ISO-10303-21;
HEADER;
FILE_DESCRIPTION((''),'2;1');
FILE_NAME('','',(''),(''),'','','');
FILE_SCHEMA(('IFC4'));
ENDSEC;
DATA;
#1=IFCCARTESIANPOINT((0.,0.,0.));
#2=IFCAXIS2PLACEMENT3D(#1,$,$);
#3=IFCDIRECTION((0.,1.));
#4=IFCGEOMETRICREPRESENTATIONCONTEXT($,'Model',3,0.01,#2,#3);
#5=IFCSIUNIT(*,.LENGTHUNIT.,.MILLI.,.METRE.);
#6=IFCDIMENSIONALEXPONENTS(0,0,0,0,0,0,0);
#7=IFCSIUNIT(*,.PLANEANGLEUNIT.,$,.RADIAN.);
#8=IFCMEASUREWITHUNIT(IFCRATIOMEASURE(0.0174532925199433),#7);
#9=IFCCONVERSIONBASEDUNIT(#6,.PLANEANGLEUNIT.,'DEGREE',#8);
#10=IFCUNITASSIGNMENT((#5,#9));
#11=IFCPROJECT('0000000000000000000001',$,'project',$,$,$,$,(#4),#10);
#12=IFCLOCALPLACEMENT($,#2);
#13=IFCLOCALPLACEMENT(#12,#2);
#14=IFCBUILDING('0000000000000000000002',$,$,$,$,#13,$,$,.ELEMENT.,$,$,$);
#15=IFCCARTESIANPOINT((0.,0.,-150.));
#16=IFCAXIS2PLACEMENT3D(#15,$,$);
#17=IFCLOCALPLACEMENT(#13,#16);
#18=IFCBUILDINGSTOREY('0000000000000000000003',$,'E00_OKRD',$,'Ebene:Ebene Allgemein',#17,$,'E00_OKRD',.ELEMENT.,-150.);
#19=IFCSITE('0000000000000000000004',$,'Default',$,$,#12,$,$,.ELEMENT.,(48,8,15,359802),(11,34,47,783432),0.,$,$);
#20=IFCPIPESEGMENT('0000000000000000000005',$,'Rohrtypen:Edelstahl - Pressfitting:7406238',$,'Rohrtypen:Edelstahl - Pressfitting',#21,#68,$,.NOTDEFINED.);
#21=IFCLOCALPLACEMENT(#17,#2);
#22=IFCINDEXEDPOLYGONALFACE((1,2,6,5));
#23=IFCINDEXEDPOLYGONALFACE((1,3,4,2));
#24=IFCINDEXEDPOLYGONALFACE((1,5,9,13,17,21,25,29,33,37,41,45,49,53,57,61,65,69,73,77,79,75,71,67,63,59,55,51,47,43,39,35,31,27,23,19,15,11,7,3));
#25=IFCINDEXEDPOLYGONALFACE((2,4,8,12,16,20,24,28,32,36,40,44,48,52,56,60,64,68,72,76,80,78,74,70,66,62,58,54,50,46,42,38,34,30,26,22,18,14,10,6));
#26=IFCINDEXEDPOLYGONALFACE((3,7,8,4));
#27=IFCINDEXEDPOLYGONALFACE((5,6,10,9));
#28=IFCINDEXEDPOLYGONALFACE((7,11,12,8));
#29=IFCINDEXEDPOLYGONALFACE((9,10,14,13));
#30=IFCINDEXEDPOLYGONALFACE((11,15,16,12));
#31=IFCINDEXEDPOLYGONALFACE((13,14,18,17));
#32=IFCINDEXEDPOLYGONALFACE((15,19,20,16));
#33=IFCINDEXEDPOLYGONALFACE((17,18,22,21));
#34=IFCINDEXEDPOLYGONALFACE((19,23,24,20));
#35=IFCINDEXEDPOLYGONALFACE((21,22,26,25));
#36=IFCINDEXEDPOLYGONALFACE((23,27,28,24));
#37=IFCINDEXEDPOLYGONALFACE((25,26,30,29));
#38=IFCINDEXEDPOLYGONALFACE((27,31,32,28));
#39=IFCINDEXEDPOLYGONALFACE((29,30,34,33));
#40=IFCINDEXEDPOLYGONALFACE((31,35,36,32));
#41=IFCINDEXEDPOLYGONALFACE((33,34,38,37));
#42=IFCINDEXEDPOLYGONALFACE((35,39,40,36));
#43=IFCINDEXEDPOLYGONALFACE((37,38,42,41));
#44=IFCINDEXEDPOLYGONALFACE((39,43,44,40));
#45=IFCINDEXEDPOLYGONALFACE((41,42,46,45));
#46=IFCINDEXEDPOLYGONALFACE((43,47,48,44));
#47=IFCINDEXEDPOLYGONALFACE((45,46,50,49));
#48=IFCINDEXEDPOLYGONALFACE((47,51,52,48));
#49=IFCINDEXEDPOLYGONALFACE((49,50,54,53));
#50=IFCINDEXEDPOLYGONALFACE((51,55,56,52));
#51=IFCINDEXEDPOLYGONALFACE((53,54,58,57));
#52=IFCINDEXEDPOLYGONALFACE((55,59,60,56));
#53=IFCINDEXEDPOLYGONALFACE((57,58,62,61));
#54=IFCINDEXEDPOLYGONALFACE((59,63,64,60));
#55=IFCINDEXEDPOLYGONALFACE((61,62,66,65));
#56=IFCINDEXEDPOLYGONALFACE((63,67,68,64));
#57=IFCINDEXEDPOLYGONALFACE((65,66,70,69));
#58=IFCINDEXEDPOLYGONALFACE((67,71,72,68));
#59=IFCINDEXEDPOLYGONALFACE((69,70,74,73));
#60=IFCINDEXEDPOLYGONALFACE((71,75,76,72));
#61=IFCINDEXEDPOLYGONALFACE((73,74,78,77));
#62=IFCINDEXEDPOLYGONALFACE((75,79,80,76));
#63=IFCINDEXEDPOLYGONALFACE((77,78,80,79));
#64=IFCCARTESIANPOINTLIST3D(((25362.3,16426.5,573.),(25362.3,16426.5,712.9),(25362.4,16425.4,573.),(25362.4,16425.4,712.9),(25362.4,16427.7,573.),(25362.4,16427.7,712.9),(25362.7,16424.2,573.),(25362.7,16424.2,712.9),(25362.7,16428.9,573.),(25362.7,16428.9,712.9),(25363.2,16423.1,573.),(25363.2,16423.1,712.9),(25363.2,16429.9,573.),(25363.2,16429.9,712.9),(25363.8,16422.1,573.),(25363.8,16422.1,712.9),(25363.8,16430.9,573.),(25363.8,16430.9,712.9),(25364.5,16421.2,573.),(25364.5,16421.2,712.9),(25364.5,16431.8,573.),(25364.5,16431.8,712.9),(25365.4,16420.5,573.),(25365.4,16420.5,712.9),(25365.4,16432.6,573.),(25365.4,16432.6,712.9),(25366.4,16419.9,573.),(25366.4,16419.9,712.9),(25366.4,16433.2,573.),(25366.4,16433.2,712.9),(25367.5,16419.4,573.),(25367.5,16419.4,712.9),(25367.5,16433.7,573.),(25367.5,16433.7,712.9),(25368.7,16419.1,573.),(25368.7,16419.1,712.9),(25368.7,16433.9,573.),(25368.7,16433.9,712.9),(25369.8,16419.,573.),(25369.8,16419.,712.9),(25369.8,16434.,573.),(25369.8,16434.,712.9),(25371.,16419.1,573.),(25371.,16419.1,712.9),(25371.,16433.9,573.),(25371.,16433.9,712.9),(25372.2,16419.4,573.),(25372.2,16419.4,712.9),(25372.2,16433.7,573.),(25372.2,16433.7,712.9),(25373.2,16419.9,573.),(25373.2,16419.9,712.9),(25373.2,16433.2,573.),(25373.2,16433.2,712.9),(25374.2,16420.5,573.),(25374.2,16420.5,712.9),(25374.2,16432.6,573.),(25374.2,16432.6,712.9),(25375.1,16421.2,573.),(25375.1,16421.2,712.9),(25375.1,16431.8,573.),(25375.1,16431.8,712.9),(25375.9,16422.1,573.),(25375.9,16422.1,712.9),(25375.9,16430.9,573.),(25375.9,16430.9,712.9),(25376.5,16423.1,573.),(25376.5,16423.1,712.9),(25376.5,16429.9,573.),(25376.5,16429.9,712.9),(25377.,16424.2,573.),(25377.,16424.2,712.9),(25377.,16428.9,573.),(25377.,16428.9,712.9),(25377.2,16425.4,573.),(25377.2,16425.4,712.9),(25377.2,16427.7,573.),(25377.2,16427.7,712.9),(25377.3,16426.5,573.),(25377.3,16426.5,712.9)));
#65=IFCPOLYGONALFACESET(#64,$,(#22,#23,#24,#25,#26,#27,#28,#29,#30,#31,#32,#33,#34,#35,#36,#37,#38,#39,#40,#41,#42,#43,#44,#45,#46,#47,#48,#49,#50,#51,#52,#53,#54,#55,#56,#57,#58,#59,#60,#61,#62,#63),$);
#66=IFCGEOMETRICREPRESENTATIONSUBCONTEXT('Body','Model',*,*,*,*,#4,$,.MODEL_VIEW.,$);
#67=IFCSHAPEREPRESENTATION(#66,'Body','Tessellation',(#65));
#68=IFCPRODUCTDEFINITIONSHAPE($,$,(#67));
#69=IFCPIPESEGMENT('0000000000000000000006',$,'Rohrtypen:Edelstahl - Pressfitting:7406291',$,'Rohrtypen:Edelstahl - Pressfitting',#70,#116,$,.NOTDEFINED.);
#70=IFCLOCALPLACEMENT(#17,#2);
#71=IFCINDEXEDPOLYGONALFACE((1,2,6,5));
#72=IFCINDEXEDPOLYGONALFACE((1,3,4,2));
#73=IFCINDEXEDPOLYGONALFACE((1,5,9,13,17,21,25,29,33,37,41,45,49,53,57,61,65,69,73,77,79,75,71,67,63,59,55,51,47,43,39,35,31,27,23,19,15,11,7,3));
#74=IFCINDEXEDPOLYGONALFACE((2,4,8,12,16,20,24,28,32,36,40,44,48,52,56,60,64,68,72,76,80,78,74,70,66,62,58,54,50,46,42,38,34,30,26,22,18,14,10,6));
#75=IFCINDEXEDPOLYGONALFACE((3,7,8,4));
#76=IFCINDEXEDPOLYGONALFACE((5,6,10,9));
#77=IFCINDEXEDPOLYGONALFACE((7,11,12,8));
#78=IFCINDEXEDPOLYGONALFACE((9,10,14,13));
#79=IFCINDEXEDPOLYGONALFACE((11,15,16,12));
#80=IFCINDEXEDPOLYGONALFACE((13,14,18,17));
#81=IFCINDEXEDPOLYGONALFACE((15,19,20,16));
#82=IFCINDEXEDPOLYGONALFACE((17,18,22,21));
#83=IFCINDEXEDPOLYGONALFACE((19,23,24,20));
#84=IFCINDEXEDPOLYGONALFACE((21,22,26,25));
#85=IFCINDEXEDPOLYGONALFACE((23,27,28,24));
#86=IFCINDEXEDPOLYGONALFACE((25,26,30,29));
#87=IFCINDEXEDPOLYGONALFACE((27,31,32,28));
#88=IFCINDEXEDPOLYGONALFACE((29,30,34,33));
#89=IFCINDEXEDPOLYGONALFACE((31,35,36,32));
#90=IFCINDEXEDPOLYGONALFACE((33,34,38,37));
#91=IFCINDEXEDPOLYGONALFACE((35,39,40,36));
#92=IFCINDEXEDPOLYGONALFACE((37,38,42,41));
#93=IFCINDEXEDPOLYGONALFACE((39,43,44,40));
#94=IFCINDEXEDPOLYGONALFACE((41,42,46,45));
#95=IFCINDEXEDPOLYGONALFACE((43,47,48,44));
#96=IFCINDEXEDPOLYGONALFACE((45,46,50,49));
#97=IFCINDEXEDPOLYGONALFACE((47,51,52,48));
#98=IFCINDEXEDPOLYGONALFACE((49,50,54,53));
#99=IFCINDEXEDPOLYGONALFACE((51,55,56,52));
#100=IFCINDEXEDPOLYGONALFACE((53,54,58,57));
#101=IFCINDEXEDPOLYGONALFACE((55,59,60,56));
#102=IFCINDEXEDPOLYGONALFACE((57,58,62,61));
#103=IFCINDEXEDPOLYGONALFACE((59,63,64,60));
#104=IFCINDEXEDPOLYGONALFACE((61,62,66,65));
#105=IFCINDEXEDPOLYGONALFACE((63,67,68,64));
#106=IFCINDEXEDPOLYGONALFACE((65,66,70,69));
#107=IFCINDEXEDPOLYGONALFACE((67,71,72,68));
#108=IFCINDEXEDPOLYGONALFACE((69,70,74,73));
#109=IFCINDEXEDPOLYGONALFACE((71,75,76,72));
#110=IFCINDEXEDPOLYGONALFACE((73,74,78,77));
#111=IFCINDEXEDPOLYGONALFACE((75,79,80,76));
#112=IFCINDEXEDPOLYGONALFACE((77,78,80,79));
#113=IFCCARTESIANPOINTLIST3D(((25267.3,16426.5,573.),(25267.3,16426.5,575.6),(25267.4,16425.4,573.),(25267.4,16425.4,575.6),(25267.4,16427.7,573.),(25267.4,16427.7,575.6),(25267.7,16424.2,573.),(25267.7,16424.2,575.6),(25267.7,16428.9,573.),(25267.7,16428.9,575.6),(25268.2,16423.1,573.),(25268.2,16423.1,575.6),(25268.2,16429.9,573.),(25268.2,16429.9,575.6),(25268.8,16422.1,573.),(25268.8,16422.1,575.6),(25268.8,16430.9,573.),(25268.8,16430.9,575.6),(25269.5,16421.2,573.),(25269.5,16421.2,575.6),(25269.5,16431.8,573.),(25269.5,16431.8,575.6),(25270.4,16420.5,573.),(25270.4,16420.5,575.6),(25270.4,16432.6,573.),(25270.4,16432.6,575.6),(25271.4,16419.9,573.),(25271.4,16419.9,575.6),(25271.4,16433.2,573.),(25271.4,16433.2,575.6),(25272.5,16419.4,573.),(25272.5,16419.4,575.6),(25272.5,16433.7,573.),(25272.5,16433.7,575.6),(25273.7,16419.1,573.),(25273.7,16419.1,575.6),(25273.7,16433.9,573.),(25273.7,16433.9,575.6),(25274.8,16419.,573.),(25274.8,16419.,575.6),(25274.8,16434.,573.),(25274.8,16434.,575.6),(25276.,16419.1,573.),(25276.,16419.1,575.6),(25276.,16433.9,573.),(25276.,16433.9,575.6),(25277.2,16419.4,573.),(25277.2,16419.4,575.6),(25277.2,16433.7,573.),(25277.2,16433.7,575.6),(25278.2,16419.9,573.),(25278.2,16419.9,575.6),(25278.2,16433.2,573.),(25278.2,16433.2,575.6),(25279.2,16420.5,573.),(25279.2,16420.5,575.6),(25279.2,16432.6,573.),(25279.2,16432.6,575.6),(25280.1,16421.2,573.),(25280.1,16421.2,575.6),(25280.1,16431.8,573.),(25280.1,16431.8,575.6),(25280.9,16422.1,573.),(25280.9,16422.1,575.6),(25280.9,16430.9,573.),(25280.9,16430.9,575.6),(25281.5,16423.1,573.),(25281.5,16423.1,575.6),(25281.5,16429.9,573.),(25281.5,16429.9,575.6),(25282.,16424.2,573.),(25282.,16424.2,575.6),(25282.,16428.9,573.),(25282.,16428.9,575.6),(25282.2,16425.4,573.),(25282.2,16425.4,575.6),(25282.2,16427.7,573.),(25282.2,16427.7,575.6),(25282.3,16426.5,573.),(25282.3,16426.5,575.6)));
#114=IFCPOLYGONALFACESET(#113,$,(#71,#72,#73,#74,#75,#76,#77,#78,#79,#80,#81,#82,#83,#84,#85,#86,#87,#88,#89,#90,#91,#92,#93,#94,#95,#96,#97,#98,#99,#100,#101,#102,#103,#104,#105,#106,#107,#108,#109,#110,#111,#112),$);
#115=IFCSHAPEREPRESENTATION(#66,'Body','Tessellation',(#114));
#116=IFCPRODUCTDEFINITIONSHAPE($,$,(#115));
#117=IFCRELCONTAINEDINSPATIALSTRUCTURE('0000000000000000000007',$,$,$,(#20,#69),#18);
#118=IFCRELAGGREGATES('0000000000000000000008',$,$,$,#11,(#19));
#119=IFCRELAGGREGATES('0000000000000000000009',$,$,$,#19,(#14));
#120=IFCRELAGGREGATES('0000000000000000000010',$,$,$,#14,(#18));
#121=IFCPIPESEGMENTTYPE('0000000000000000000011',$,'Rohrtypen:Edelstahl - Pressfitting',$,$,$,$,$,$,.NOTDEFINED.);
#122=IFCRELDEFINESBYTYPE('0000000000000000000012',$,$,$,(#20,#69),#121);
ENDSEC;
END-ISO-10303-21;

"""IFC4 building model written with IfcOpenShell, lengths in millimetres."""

from ifc_helpers import new_model, entity, si_unit, converted_unit, direction, frame, origin, place, context, subcontext, project, spatial, indexed_curve, outline, extrude, type_object, element, save


model = new_model("IFC4")

# Units and contexts
model_context = context("Model", 3, precision=0.01, world=origin(), true_north=direction((0.0, 1.0)))
body_context = subcontext(model_context, "Body", "Model", "MODEL_VIEW")
ifc_project = project(units=[si_unit("LENGTHUNIT", "METRE", prefix="MILLI"), converted_unit("PLANEANGLEUNIT", "DEGREE", entity("IfcRatioMeasure", 0.0174532925199433), si_unit("PLANEANGLEUNIT", "RADIAN"), dimensions=[0, 0, 0, 0, 0, 0, 0])], contexts=[model_context])

# Site, building, storey
site_placement = place(None, origin())
site = spatial("IfcSite", under=ifc_project, at=site_placement, Name="Default", CompositionType="ELEMENT", RefLatitude=(48, 8, 15, 359802), RefLongitude=(11, 34, 47, 783432), RefElevation=0.0)
building_placement = place(site_placement, origin())
building = spatial("IfcBuilding", under=site, at=building_placement, CompositionType="ELEMENT")
storey_placement = place(building_placement, frame((0.0, 0.0, -150.0)))
storey = spatial("IfcBuildingStorey", under=building, at=storey_placement, Name="E00_OKRD", ObjectType="Ebene:Ebene Allgemein", LongName="E00_OKRD", CompositionType="ELEMENT", Elevation=-150.0)

# Pipe segments
pipe_segment_type_1 = type_object("IfcPipeSegmentType", Name="Rohrtypen:Edelstahl - Pressfitting", PredefinedType="NOTDEFINED")
pipe_segment_1_placement = place(storey_placement, origin())
element("IfcPipeSegment", 1, at=pipe_segment_1_placement, inside=storey, type_object=pipe_segment_type_1, Name="Rohrtypen:Edelstahl - Pressfitting:7406238", ObjectType="Rohrtypen:Edelstahl - Pressfitting", PredefinedType="NOTDEFINED", context=body_context, shape_type="SweptSolid", body=[
    extrude(outline(indexed_curve([(7.5, 0.0), (7.4, 1.2), (7.1, 2.3), (6.7, 3.4), (6.1, 4.4), (5.3, 5.3), (4.4, 6.1), (3.4, 6.7), (2.3, 7.1), (1.2, 7.4), (0.0, 7.5), (-1.2, 7.4), (-2.3, 7.1), (-3.4, 6.7), (-4.4, 6.1), (-5.3, 5.3), (-6.1, 4.4), (-6.7, 3.4), (-7.1, 2.3), (-7.4, 1.2), (-7.5, 0.0), (-7.4, -1.2), (-7.1, -2.3), (-6.7, -3.4), (-6.1, -4.4), (-5.3, -5.3), (-4.4, -6.1), (-3.4, -6.7), (-2.3, -7.1), (-1.2, -7.4), (0.0, -7.5), (1.2, -7.4), (2.3, -7.1), (3.4, -6.7), (4.4, -6.1), (5.3, -5.3), (6.1, -4.4), (6.7, -3.4), (7.1, -2.3), (7.4, -1.2), (7.5, 0.0)], self_intersect=False)), frame((25369.8, 16426.5, 573.0), z_axis=(0.0, 0.0, 1.0), x_axis=(-1.0, 0.0, 0.0)), (0.0, 0.0, 1.0), 139.9),
])
pipe_segment_2_placement = place(storey_placement, origin())
element("IfcPipeSegment", 2, at=pipe_segment_2_placement, inside=storey, type_object=pipe_segment_type_1, Name="Rohrtypen:Edelstahl - Pressfitting:7406291", ObjectType="Rohrtypen:Edelstahl - Pressfitting", PredefinedType="NOTDEFINED", context=body_context, shape_type="SweptSolid", body=[
    extrude(outline(indexed_curve([(7.5, 0.0), (7.4, 1.2), (7.1, 2.3), (6.7, 3.4), (6.1, 4.4), (5.3, 5.3), (4.4, 6.1), (3.4, 6.7), (2.3, 7.1), (1.2, 7.4), (0.0, 7.5), (-1.2, 7.4), (-2.3, 7.1), (-3.4, 6.7), (-4.4, 6.1), (-5.3, 5.3), (-6.1, 4.4), (-6.7, 3.4), (-7.1, 2.3), (-7.4, 1.2), (-7.5, 0.0), (-7.4, -1.2), (-7.1, -2.3), (-6.7, -3.4), (-6.1, -4.4), (-5.3, -5.3), (-4.4, -6.1), (-3.4, -6.7), (-2.3, -7.1), (-1.2, -7.4), (0.0, -7.5), (1.2, -7.4), (2.3, -7.1), (3.4, -6.7), (4.4, -6.1), (5.3, -5.3), (6.1, -4.4), (6.7, -3.4), (7.1, -2.3), (7.4, -1.2), (7.5, 0.0)], self_intersect=False)), frame((25274.8, 16426.5, 573.0), z_axis=(0.0, 0.0, 1.0), x_axis=(-1.0, 0.0, 0.0)), (0.0, 0.0, 1.0), 2.6),
])

save(model, "model.ifc")
